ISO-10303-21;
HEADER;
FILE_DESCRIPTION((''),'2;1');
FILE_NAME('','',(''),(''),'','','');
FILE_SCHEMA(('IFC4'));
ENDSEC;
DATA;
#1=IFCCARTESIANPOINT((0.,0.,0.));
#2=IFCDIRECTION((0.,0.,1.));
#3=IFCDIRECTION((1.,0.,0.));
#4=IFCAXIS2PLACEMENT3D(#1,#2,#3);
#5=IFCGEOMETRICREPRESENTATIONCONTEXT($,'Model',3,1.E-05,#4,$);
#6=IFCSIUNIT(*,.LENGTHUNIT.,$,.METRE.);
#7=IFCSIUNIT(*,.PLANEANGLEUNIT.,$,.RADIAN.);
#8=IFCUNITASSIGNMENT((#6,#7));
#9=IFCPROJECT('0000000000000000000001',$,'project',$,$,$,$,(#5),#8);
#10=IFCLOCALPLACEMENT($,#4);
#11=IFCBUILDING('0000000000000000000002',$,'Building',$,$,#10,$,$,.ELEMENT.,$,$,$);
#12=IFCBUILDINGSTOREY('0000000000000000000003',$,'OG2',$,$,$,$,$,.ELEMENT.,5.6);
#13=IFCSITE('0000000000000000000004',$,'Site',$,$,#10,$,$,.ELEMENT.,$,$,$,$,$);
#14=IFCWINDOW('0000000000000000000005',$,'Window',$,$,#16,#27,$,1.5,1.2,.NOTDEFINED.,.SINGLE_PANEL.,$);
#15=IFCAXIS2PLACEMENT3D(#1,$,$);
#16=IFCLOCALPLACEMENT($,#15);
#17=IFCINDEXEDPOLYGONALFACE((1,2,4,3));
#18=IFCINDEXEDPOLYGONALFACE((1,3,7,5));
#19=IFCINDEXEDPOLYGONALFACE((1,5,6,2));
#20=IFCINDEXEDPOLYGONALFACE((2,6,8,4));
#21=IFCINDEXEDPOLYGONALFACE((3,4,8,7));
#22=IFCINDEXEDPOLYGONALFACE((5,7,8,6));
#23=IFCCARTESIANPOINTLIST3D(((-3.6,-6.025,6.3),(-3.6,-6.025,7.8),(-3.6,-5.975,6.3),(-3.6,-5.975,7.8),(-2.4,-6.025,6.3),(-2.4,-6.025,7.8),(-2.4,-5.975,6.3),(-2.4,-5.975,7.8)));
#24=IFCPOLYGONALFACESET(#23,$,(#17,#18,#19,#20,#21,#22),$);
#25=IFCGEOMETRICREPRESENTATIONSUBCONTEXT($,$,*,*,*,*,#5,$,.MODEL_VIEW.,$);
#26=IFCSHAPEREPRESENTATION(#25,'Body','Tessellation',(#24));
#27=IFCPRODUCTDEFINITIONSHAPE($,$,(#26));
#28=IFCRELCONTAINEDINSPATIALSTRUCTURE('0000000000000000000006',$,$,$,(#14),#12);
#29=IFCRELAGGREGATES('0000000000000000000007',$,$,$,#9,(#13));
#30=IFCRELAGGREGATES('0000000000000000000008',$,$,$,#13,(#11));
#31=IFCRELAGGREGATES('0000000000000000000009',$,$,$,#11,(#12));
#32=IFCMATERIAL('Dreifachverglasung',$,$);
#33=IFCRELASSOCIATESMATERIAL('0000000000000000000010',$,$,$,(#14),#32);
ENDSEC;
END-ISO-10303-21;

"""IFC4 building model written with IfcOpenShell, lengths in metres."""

from ifc_helpers import new_model, si_unit, frame, origin, origin_with_axes, origin_2d, place, context, subcontext, project, spatial, rectangle, extrude, material, element, save


model = new_model("IFC4")

# Units and contexts
model_context = context("Model", 3, precision=1e-05, world=origin_with_axes())
sub_context = subcontext(model_context, None, None, "MODEL_VIEW")
ifc_project = project(units=[si_unit("LENGTHUNIT", "METRE"), si_unit("PLANEANGLEUNIT", "RADIAN")], contexts=[model_context])

# Site, building, storey
placement_1 = place(None, origin_with_axes())
site = spatial("IfcSite", under=ifc_project, at=placement_1, Name="Site", CompositionType="ELEMENT")
building = spatial("IfcBuilding", under=site, at=placement_1, Name="Building", CompositionType="ELEMENT")
storey = spatial("IfcBuildingStorey", under=building, Name="OG2", CompositionType="ELEMENT", Elevation=5.6)

# Window
ifc_material = material(Name="Dreifachverglasung")
placement_2 = place(None, origin_with_axes())
window_placement = place(placement_2, frame((-3.0, -6.0, 6.3)))
element("IfcWindow", 1, at=window_placement, inside=storey, material=ifc_material, Name="Window", OverallHeight=1.5, OverallWidth=1.2, PartitioningType="SINGLE_PANEL", PredefinedType="NOTDEFINED", context=sub_context, shape_type="SweptSolid", body=[
    extrude(rectangle(XDim=1.2, YDim=0.05, at=origin_2d()), origin(), (0.0, 0.0, 1.0), 1.5),
])

save(model, "model.ifc")
